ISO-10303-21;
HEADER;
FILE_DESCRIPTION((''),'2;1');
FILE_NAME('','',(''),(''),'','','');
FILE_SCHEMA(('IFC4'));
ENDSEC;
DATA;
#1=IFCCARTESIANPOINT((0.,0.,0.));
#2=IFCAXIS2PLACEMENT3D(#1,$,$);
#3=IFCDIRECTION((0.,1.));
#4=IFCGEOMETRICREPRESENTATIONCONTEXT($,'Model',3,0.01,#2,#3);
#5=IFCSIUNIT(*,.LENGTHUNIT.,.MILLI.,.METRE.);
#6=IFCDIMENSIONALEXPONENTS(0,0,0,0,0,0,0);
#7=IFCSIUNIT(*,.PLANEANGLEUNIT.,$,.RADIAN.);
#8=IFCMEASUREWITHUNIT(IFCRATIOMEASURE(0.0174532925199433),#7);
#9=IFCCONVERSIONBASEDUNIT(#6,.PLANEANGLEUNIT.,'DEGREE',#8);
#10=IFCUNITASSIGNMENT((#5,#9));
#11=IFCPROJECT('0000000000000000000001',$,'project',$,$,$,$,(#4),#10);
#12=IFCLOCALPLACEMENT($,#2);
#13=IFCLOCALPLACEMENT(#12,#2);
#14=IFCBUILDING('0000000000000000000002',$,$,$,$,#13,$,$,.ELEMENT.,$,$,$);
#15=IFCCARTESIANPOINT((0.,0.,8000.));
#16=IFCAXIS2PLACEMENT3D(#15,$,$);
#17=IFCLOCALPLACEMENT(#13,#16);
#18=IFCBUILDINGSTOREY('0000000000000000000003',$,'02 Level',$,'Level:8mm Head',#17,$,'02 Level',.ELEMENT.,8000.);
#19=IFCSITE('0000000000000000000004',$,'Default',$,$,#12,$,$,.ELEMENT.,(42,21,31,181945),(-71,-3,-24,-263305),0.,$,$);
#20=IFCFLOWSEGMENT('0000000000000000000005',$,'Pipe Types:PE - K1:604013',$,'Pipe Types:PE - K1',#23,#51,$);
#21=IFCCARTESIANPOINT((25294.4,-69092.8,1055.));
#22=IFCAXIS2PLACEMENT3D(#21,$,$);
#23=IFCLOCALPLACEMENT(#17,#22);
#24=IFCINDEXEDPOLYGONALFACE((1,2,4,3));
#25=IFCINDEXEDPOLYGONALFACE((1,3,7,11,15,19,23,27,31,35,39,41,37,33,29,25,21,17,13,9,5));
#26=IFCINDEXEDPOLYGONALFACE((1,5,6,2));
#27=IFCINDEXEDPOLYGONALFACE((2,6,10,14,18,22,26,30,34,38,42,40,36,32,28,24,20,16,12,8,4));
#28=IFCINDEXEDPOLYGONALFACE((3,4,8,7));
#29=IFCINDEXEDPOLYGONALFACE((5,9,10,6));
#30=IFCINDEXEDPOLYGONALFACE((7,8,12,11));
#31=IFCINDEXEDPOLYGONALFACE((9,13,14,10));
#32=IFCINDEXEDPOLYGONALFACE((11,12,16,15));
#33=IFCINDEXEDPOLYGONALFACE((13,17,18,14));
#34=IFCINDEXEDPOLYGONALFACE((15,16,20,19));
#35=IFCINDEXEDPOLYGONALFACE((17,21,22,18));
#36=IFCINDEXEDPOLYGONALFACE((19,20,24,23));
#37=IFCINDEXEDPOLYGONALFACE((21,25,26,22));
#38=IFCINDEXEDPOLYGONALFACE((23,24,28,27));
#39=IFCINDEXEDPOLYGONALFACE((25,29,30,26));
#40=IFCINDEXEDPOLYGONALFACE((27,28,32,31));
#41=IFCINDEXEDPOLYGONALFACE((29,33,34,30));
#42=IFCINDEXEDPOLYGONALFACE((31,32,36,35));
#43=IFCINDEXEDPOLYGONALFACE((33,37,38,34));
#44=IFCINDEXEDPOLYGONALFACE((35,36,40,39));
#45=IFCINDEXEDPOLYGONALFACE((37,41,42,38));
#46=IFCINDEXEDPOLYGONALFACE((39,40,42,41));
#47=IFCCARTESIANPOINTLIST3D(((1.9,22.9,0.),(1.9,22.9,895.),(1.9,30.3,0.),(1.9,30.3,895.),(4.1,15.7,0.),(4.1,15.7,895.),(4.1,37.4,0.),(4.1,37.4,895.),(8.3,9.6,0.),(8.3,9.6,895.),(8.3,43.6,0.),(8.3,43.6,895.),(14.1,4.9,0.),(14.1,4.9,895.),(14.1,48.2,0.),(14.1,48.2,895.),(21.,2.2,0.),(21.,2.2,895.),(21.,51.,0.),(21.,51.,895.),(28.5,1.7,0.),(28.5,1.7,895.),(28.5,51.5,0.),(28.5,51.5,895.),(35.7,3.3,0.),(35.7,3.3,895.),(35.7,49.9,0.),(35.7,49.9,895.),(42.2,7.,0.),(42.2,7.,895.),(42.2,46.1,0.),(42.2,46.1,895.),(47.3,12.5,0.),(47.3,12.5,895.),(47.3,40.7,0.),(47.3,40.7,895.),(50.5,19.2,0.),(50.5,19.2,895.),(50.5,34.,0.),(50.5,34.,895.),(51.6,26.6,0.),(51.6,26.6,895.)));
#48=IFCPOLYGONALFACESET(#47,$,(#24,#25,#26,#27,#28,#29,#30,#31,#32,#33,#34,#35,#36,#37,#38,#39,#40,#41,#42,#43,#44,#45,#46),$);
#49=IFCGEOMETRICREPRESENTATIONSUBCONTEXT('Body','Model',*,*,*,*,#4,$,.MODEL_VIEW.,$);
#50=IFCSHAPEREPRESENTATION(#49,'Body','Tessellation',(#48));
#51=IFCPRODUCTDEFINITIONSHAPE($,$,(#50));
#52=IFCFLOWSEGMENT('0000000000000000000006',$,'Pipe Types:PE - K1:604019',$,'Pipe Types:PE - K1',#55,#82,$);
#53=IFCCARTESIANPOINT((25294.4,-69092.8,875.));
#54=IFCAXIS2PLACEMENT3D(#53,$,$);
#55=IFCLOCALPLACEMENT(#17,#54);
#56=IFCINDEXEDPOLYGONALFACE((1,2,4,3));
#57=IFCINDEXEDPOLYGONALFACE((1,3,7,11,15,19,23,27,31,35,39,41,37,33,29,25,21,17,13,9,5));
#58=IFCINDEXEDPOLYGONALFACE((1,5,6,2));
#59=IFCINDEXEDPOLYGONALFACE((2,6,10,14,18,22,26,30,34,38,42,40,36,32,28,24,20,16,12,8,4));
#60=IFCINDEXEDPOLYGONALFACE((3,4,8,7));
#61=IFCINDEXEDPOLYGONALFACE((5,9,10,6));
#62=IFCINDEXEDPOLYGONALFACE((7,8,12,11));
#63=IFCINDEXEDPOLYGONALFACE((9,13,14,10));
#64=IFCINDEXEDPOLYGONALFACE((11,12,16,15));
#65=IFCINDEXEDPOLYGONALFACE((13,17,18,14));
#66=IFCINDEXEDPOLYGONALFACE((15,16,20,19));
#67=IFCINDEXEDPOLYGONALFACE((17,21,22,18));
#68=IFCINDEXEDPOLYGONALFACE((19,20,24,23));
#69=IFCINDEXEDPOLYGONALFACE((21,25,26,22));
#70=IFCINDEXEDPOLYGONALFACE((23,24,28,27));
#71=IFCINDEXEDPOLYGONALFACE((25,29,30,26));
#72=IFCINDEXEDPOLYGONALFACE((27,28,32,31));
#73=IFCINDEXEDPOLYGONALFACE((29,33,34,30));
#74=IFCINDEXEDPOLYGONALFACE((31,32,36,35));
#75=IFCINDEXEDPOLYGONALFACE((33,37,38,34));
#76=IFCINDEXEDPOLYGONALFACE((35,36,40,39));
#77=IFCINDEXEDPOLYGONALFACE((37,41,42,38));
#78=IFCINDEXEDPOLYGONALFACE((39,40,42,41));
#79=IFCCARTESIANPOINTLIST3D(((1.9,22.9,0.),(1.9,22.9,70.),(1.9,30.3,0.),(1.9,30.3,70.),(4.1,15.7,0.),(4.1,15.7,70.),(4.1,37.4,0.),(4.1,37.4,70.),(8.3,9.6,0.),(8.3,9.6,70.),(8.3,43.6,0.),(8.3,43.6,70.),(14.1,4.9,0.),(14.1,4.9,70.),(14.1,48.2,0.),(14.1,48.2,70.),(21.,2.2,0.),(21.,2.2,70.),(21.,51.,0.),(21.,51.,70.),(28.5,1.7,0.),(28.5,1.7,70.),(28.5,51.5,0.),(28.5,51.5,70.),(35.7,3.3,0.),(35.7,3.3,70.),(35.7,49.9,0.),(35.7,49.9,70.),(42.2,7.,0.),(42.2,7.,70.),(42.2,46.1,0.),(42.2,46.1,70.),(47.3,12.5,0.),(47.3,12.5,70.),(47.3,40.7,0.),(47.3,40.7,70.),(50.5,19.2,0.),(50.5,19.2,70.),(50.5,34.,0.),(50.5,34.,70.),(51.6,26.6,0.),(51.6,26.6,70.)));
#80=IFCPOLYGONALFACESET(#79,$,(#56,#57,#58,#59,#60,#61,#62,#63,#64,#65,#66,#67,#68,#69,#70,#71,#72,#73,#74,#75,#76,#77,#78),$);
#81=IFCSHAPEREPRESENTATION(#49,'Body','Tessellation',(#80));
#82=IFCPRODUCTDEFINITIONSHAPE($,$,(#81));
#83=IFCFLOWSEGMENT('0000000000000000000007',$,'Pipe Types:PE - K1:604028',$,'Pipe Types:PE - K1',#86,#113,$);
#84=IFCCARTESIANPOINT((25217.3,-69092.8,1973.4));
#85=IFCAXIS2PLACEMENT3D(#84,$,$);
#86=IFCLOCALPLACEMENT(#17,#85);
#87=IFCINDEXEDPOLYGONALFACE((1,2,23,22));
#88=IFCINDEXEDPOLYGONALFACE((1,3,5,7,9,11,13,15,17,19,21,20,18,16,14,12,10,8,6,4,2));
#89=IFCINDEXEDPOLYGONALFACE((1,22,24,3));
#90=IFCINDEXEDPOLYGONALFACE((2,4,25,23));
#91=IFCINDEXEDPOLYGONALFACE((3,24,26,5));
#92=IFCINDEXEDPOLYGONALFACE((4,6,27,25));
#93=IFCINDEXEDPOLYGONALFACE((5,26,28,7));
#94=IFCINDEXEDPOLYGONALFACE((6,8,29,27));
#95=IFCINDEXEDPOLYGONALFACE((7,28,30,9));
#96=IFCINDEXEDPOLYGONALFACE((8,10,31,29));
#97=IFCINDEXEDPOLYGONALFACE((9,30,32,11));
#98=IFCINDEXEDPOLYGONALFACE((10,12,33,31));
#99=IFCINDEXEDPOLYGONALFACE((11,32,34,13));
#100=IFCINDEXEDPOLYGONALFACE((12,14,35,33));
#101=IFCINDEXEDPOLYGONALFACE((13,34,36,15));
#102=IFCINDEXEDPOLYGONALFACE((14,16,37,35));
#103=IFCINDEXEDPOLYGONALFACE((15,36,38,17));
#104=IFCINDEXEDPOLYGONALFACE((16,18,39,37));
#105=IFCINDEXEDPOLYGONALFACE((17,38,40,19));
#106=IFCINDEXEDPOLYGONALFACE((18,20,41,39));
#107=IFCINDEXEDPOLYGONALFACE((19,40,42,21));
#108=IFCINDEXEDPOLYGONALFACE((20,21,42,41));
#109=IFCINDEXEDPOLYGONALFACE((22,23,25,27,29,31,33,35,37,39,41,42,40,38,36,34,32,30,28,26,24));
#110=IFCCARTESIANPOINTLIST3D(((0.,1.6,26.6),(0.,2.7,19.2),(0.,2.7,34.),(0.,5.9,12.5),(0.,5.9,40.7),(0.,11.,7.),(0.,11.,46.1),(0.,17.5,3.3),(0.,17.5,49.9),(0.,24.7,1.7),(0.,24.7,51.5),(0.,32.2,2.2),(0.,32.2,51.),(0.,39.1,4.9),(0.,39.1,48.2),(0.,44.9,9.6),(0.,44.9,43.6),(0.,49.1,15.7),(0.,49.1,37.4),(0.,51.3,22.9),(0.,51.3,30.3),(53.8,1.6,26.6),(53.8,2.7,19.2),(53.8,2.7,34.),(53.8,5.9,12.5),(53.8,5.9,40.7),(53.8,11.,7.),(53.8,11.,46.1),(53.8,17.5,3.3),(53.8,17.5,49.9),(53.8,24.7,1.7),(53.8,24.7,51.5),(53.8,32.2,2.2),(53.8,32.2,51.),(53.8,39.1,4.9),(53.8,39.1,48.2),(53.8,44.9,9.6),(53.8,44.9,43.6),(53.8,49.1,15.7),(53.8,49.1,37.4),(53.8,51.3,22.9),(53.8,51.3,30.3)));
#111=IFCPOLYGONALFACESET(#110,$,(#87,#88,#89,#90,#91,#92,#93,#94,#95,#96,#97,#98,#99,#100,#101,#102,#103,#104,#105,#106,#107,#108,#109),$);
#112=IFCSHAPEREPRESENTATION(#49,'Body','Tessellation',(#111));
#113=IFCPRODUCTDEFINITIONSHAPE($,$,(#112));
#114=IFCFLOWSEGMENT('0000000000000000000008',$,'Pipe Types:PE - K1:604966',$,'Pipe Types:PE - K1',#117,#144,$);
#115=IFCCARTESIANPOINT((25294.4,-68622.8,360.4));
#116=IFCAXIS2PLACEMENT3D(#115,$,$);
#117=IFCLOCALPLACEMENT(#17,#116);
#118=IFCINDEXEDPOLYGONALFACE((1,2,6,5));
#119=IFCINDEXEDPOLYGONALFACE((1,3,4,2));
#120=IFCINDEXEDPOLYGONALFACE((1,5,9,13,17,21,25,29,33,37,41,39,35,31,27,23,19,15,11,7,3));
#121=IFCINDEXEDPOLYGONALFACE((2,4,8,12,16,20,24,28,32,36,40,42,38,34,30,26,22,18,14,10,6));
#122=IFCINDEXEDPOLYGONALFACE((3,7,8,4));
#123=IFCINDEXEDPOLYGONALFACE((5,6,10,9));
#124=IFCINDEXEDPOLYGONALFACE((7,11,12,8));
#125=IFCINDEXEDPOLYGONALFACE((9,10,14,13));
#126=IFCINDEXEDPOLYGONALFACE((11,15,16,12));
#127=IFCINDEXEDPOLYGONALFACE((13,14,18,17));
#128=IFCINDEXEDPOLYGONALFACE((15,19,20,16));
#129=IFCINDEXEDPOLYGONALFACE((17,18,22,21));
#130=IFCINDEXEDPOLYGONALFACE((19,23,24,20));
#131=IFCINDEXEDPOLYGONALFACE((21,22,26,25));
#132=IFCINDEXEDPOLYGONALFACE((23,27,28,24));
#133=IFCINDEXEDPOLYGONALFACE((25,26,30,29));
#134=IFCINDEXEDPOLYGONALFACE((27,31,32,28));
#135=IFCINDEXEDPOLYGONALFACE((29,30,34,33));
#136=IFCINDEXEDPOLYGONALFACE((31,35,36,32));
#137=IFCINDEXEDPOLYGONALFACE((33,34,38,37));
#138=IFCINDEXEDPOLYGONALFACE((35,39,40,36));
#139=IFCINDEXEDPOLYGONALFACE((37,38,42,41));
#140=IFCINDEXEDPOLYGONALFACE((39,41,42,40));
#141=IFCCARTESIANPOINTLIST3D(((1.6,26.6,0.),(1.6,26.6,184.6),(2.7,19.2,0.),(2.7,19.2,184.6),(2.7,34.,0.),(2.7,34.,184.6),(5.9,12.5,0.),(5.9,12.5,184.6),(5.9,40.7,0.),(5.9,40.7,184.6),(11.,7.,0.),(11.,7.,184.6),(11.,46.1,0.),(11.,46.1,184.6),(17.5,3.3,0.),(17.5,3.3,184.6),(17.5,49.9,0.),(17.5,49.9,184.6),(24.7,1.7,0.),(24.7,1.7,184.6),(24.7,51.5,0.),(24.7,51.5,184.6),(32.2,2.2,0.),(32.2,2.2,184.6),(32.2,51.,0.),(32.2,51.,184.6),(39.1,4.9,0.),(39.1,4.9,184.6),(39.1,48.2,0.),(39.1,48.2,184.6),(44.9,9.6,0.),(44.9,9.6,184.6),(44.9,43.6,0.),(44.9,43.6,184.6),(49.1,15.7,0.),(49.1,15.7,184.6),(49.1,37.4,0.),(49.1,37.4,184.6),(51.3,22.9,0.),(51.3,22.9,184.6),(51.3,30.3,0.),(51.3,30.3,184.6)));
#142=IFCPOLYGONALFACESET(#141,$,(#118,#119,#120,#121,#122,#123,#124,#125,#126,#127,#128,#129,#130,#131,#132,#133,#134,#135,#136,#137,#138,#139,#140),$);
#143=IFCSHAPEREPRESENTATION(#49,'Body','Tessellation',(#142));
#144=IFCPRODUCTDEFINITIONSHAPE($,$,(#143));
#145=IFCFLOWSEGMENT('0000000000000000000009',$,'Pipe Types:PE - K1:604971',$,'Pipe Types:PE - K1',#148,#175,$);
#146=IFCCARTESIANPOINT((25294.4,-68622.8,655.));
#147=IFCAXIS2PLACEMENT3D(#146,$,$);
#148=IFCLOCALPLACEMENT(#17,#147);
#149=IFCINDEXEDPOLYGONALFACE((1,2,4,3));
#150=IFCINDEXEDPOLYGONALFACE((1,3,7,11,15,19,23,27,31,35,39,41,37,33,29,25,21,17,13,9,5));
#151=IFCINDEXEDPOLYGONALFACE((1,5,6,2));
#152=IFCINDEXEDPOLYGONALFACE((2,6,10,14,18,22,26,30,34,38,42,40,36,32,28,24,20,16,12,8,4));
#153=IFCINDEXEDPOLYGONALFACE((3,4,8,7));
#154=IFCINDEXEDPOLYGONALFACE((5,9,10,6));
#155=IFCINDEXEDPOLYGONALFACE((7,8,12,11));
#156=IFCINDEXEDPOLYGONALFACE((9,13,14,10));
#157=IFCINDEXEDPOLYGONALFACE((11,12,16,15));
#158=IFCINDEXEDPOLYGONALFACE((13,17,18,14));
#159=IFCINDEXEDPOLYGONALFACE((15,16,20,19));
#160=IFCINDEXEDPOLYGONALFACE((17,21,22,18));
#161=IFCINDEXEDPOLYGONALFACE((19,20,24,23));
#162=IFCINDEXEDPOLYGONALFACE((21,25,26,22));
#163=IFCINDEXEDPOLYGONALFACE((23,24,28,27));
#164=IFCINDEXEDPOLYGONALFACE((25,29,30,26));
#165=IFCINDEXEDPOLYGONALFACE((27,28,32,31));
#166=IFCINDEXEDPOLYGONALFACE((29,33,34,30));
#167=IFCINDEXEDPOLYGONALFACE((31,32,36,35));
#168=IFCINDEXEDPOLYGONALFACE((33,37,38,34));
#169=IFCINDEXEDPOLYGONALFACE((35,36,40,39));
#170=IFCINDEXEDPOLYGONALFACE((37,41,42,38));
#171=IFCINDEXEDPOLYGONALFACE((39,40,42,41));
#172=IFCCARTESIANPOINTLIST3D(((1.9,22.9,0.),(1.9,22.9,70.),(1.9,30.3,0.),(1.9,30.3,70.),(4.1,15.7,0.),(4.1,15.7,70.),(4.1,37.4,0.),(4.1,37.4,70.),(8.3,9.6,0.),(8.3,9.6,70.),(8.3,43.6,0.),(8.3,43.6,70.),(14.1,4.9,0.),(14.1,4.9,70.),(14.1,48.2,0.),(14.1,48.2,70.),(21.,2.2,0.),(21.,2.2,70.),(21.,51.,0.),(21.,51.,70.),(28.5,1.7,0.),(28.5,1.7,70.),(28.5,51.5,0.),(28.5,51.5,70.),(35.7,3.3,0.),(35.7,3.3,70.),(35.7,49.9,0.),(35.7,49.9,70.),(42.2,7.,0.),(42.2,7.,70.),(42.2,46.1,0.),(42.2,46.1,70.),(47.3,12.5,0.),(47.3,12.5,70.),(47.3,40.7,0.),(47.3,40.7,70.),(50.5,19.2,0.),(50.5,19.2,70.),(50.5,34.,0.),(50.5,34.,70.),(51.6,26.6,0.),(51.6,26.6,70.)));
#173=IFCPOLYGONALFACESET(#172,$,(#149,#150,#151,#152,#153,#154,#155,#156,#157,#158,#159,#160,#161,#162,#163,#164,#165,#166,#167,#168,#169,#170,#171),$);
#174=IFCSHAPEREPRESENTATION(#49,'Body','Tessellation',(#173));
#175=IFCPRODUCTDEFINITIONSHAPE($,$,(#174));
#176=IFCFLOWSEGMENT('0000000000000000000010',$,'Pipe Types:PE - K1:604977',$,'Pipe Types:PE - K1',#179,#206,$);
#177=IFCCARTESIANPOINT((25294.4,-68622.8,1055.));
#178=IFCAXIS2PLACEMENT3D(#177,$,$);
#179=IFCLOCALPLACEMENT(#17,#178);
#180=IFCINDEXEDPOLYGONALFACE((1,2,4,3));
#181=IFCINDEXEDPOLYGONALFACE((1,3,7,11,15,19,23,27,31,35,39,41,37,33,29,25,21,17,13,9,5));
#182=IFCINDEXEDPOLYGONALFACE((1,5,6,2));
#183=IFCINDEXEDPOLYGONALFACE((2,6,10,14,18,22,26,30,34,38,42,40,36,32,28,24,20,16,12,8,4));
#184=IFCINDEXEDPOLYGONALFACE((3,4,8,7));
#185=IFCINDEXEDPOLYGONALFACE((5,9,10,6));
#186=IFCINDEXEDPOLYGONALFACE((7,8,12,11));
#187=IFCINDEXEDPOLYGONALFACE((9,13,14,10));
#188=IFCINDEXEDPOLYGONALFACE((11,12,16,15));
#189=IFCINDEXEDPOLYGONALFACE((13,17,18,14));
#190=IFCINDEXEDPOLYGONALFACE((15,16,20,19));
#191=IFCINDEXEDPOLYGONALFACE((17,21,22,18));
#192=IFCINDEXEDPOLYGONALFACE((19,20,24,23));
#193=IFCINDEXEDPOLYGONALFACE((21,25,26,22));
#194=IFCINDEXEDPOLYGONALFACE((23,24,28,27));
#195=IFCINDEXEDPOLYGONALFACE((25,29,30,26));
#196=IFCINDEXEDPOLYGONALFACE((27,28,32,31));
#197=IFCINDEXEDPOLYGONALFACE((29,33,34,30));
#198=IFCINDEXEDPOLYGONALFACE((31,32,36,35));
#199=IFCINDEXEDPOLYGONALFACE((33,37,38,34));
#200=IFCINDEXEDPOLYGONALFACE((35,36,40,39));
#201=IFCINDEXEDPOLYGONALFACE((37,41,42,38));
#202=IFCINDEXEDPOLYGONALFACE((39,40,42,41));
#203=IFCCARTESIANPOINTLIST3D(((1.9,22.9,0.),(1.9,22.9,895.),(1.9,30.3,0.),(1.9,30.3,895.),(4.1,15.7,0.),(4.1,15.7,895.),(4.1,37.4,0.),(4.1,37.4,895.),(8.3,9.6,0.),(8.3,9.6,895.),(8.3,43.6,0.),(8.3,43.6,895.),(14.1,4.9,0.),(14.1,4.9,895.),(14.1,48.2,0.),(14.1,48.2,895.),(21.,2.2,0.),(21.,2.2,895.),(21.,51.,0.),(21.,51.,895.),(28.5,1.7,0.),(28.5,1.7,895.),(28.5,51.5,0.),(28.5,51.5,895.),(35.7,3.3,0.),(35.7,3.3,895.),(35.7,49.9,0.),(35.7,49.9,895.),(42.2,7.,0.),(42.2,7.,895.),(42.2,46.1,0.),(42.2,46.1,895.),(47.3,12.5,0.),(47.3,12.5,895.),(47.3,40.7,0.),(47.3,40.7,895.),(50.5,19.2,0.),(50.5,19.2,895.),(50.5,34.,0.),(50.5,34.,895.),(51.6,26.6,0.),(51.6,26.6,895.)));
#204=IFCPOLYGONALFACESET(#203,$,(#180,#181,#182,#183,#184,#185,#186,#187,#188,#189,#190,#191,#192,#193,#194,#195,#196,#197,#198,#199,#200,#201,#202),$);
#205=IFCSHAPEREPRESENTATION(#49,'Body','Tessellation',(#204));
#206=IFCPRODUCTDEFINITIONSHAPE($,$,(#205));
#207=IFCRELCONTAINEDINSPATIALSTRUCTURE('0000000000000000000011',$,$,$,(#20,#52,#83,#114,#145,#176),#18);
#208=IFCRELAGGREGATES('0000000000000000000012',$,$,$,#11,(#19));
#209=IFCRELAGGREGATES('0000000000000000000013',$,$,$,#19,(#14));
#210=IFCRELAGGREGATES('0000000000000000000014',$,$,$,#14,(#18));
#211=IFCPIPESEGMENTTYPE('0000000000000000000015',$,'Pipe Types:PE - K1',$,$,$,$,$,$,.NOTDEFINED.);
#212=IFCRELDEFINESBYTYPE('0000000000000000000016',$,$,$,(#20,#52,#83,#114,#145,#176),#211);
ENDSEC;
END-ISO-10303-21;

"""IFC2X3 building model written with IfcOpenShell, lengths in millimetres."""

from ifc_helpers import new_model, entity, si_unit, converted_unit, direction, frame, frame_2d, origin, origin_2d_with_axis, place, context, subcontext, project, spatial, circle, extrude, type_object, element, save


model = new_model("IFC2X3")

# Units and contexts
model_context = context("Model", 3, precision=0.01, world=origin(), true_north=direction((0.0, 1.0)))
body_context = subcontext(model_context, "Body", "Model", "MODEL_VIEW")
ifc_project = project(units=[si_unit("LENGTHUNIT", "METRE", prefix="MILLI"), converted_unit("PLANEANGLEUNIT", "DEGREE", entity("IfcRatioMeasure", 0.0174532925199433), si_unit("PLANEANGLEUNIT", "RADIAN"), dimensions=[0, 0, 0, 0, 0, 0, 0])], contexts=[model_context])

# Site, building, storey
site_placement = place(None, origin())
site = spatial("IfcSite", under=ifc_project, at=site_placement, Name="Default", CompositionType="ELEMENT", RefLatitude=(42, 21, 31, 181945), RefLongitude=(-71, -3, -24, -263305), RefElevation=0.0)
building_placement = place(site_placement, origin())
building = spatial("IfcBuilding", under=site, at=building_placement, CompositionType="ELEMENT")
storey_placement = place(building_placement, frame((0.0, 0.0, 8000.0)))
storey = spatial("IfcBuildingStorey", under=building, at=storey_placement, Name="02 Level", ObjectType="Level:8mm Head", LongName="02 Level", CompositionType="ELEMENT", Elevation=8000.0)

# Flow segments
pipe_segment_type_1 = type_object("IfcPipeSegmentType", Name="Pipe Types:PE - K1", PredefinedType="NOTDEFINED")
flow_segment_1_placement = place(storey_placement, frame((25294.4, -69092.8, 1055.0)))
element("IfcFlowSegment", 1, at=flow_segment_1_placement, inside=storey, type_object=pipe_segment_type_1, Name="Pipe Types:PE - K1:604013", ObjectType="Pipe Types:PE - K1", context=body_context, shape_type="SweptSolid", body=[
    extrude(circle(Radius=25.0, at=frame_2d((0.0, 0.0), x_axis=(1.0, 0.0))), frame((26.6, 26.6, 0.0)), (0.0, 0.0, 1.0), 895.0),
])
flow_segment_2_placement = place(storey_placement, frame((25294.4, -69092.8, 875.0)))
element("IfcFlowSegment", 2, at=flow_segment_2_placement, inside=storey, type_object=pipe_segment_type_1, Name="Pipe Types:PE - K1:604019", ObjectType="Pipe Types:PE - K1", context=body_context, shape_type="SweptSolid", body=[
    extrude(circle(Radius=25.0, at=origin_2d_with_axis()), frame((26.6, 26.6, 0.0)), (0.0, 0.0, 1.0), 70.0),
])
flow_segment_3_placement = place(storey_placement, frame((25217.3, -69092.8, 1973.4)))
element("IfcFlowSegment", 3, at=flow_segment_3_placement, inside=storey, type_object=pipe_segment_type_1, Name="Pipe Types:PE - K1:604028", ObjectType="Pipe Types:PE - K1", context=body_context, shape_type="SweptSolid", body=[
    extrude(circle(Radius=25.0, at=frame_2d((0.0, 0.0), x_axis=(1.0, 0.0))), frame((0.0, 26.6, 26.6), z_axis=(1.0, 0.0, 0.0), x_axis=(0.0, -1.0, 0.0)), (0.0, 0.0, 1.0), 53.8),
])
flow_segment_4_placement = place(storey_placement, frame((25294.4, -68622.8, 360.4)))
element("IfcFlowSegment", 4, at=flow_segment_4_placement, inside=storey, type_object=pipe_segment_type_1, Name="Pipe Types:PE - K1:604966", ObjectType="Pipe Types:PE - K1", context=body_context, shape_type="SweptSolid", body=[
    extrude(circle(Radius=25.0, at=frame_2d((0.0, 0.0), x_axis=(1.0, 0.0))), frame((26.6, 26.6, 0.0), z_axis=(0.0, 0.0, 1.0), x_axis=(-1.0, 0.0, 0.0)), (0.0, 0.0, 1.0), 184.6),
])
flow_segment_5_placement = place(storey_placement, frame((25294.4, -68622.8, 655.0)))
element("IfcFlowSegment", 5, at=flow_segment_5_placement, inside=storey, type_object=pipe_segment_type_1, Name="Pipe Types:PE - K1:604971", ObjectType="Pipe Types:PE - K1", context=body_context, shape_type="SweptSolid", body=[
    extrude(circle(Radius=25.0, at=frame_2d((0.0, 0.0), x_axis=(1.0, 0.0))), frame((26.6, 26.6, 0.0)), (0.0, 0.0, 1.0), 70.0),
])
flow_segment_6_placement = place(storey_placement, frame((25294.4, -68622.8, 1055.0)))
element("IfcFlowSegment", 6, at=flow_segment_6_placement, inside=storey, type_object=pipe_segment_type_1, Name="Pipe Types:PE - K1:604977", ObjectType="Pipe Types:PE - K1", context=body_context, shape_type="SweptSolid", body=[
    extrude(circle(Radius=25.0, at=origin_2d_with_axis()), frame((26.6, 26.6, 0.0)), (0.0, 0.0, 1.0), 895.0),
])

save(model, "model.ifc")
